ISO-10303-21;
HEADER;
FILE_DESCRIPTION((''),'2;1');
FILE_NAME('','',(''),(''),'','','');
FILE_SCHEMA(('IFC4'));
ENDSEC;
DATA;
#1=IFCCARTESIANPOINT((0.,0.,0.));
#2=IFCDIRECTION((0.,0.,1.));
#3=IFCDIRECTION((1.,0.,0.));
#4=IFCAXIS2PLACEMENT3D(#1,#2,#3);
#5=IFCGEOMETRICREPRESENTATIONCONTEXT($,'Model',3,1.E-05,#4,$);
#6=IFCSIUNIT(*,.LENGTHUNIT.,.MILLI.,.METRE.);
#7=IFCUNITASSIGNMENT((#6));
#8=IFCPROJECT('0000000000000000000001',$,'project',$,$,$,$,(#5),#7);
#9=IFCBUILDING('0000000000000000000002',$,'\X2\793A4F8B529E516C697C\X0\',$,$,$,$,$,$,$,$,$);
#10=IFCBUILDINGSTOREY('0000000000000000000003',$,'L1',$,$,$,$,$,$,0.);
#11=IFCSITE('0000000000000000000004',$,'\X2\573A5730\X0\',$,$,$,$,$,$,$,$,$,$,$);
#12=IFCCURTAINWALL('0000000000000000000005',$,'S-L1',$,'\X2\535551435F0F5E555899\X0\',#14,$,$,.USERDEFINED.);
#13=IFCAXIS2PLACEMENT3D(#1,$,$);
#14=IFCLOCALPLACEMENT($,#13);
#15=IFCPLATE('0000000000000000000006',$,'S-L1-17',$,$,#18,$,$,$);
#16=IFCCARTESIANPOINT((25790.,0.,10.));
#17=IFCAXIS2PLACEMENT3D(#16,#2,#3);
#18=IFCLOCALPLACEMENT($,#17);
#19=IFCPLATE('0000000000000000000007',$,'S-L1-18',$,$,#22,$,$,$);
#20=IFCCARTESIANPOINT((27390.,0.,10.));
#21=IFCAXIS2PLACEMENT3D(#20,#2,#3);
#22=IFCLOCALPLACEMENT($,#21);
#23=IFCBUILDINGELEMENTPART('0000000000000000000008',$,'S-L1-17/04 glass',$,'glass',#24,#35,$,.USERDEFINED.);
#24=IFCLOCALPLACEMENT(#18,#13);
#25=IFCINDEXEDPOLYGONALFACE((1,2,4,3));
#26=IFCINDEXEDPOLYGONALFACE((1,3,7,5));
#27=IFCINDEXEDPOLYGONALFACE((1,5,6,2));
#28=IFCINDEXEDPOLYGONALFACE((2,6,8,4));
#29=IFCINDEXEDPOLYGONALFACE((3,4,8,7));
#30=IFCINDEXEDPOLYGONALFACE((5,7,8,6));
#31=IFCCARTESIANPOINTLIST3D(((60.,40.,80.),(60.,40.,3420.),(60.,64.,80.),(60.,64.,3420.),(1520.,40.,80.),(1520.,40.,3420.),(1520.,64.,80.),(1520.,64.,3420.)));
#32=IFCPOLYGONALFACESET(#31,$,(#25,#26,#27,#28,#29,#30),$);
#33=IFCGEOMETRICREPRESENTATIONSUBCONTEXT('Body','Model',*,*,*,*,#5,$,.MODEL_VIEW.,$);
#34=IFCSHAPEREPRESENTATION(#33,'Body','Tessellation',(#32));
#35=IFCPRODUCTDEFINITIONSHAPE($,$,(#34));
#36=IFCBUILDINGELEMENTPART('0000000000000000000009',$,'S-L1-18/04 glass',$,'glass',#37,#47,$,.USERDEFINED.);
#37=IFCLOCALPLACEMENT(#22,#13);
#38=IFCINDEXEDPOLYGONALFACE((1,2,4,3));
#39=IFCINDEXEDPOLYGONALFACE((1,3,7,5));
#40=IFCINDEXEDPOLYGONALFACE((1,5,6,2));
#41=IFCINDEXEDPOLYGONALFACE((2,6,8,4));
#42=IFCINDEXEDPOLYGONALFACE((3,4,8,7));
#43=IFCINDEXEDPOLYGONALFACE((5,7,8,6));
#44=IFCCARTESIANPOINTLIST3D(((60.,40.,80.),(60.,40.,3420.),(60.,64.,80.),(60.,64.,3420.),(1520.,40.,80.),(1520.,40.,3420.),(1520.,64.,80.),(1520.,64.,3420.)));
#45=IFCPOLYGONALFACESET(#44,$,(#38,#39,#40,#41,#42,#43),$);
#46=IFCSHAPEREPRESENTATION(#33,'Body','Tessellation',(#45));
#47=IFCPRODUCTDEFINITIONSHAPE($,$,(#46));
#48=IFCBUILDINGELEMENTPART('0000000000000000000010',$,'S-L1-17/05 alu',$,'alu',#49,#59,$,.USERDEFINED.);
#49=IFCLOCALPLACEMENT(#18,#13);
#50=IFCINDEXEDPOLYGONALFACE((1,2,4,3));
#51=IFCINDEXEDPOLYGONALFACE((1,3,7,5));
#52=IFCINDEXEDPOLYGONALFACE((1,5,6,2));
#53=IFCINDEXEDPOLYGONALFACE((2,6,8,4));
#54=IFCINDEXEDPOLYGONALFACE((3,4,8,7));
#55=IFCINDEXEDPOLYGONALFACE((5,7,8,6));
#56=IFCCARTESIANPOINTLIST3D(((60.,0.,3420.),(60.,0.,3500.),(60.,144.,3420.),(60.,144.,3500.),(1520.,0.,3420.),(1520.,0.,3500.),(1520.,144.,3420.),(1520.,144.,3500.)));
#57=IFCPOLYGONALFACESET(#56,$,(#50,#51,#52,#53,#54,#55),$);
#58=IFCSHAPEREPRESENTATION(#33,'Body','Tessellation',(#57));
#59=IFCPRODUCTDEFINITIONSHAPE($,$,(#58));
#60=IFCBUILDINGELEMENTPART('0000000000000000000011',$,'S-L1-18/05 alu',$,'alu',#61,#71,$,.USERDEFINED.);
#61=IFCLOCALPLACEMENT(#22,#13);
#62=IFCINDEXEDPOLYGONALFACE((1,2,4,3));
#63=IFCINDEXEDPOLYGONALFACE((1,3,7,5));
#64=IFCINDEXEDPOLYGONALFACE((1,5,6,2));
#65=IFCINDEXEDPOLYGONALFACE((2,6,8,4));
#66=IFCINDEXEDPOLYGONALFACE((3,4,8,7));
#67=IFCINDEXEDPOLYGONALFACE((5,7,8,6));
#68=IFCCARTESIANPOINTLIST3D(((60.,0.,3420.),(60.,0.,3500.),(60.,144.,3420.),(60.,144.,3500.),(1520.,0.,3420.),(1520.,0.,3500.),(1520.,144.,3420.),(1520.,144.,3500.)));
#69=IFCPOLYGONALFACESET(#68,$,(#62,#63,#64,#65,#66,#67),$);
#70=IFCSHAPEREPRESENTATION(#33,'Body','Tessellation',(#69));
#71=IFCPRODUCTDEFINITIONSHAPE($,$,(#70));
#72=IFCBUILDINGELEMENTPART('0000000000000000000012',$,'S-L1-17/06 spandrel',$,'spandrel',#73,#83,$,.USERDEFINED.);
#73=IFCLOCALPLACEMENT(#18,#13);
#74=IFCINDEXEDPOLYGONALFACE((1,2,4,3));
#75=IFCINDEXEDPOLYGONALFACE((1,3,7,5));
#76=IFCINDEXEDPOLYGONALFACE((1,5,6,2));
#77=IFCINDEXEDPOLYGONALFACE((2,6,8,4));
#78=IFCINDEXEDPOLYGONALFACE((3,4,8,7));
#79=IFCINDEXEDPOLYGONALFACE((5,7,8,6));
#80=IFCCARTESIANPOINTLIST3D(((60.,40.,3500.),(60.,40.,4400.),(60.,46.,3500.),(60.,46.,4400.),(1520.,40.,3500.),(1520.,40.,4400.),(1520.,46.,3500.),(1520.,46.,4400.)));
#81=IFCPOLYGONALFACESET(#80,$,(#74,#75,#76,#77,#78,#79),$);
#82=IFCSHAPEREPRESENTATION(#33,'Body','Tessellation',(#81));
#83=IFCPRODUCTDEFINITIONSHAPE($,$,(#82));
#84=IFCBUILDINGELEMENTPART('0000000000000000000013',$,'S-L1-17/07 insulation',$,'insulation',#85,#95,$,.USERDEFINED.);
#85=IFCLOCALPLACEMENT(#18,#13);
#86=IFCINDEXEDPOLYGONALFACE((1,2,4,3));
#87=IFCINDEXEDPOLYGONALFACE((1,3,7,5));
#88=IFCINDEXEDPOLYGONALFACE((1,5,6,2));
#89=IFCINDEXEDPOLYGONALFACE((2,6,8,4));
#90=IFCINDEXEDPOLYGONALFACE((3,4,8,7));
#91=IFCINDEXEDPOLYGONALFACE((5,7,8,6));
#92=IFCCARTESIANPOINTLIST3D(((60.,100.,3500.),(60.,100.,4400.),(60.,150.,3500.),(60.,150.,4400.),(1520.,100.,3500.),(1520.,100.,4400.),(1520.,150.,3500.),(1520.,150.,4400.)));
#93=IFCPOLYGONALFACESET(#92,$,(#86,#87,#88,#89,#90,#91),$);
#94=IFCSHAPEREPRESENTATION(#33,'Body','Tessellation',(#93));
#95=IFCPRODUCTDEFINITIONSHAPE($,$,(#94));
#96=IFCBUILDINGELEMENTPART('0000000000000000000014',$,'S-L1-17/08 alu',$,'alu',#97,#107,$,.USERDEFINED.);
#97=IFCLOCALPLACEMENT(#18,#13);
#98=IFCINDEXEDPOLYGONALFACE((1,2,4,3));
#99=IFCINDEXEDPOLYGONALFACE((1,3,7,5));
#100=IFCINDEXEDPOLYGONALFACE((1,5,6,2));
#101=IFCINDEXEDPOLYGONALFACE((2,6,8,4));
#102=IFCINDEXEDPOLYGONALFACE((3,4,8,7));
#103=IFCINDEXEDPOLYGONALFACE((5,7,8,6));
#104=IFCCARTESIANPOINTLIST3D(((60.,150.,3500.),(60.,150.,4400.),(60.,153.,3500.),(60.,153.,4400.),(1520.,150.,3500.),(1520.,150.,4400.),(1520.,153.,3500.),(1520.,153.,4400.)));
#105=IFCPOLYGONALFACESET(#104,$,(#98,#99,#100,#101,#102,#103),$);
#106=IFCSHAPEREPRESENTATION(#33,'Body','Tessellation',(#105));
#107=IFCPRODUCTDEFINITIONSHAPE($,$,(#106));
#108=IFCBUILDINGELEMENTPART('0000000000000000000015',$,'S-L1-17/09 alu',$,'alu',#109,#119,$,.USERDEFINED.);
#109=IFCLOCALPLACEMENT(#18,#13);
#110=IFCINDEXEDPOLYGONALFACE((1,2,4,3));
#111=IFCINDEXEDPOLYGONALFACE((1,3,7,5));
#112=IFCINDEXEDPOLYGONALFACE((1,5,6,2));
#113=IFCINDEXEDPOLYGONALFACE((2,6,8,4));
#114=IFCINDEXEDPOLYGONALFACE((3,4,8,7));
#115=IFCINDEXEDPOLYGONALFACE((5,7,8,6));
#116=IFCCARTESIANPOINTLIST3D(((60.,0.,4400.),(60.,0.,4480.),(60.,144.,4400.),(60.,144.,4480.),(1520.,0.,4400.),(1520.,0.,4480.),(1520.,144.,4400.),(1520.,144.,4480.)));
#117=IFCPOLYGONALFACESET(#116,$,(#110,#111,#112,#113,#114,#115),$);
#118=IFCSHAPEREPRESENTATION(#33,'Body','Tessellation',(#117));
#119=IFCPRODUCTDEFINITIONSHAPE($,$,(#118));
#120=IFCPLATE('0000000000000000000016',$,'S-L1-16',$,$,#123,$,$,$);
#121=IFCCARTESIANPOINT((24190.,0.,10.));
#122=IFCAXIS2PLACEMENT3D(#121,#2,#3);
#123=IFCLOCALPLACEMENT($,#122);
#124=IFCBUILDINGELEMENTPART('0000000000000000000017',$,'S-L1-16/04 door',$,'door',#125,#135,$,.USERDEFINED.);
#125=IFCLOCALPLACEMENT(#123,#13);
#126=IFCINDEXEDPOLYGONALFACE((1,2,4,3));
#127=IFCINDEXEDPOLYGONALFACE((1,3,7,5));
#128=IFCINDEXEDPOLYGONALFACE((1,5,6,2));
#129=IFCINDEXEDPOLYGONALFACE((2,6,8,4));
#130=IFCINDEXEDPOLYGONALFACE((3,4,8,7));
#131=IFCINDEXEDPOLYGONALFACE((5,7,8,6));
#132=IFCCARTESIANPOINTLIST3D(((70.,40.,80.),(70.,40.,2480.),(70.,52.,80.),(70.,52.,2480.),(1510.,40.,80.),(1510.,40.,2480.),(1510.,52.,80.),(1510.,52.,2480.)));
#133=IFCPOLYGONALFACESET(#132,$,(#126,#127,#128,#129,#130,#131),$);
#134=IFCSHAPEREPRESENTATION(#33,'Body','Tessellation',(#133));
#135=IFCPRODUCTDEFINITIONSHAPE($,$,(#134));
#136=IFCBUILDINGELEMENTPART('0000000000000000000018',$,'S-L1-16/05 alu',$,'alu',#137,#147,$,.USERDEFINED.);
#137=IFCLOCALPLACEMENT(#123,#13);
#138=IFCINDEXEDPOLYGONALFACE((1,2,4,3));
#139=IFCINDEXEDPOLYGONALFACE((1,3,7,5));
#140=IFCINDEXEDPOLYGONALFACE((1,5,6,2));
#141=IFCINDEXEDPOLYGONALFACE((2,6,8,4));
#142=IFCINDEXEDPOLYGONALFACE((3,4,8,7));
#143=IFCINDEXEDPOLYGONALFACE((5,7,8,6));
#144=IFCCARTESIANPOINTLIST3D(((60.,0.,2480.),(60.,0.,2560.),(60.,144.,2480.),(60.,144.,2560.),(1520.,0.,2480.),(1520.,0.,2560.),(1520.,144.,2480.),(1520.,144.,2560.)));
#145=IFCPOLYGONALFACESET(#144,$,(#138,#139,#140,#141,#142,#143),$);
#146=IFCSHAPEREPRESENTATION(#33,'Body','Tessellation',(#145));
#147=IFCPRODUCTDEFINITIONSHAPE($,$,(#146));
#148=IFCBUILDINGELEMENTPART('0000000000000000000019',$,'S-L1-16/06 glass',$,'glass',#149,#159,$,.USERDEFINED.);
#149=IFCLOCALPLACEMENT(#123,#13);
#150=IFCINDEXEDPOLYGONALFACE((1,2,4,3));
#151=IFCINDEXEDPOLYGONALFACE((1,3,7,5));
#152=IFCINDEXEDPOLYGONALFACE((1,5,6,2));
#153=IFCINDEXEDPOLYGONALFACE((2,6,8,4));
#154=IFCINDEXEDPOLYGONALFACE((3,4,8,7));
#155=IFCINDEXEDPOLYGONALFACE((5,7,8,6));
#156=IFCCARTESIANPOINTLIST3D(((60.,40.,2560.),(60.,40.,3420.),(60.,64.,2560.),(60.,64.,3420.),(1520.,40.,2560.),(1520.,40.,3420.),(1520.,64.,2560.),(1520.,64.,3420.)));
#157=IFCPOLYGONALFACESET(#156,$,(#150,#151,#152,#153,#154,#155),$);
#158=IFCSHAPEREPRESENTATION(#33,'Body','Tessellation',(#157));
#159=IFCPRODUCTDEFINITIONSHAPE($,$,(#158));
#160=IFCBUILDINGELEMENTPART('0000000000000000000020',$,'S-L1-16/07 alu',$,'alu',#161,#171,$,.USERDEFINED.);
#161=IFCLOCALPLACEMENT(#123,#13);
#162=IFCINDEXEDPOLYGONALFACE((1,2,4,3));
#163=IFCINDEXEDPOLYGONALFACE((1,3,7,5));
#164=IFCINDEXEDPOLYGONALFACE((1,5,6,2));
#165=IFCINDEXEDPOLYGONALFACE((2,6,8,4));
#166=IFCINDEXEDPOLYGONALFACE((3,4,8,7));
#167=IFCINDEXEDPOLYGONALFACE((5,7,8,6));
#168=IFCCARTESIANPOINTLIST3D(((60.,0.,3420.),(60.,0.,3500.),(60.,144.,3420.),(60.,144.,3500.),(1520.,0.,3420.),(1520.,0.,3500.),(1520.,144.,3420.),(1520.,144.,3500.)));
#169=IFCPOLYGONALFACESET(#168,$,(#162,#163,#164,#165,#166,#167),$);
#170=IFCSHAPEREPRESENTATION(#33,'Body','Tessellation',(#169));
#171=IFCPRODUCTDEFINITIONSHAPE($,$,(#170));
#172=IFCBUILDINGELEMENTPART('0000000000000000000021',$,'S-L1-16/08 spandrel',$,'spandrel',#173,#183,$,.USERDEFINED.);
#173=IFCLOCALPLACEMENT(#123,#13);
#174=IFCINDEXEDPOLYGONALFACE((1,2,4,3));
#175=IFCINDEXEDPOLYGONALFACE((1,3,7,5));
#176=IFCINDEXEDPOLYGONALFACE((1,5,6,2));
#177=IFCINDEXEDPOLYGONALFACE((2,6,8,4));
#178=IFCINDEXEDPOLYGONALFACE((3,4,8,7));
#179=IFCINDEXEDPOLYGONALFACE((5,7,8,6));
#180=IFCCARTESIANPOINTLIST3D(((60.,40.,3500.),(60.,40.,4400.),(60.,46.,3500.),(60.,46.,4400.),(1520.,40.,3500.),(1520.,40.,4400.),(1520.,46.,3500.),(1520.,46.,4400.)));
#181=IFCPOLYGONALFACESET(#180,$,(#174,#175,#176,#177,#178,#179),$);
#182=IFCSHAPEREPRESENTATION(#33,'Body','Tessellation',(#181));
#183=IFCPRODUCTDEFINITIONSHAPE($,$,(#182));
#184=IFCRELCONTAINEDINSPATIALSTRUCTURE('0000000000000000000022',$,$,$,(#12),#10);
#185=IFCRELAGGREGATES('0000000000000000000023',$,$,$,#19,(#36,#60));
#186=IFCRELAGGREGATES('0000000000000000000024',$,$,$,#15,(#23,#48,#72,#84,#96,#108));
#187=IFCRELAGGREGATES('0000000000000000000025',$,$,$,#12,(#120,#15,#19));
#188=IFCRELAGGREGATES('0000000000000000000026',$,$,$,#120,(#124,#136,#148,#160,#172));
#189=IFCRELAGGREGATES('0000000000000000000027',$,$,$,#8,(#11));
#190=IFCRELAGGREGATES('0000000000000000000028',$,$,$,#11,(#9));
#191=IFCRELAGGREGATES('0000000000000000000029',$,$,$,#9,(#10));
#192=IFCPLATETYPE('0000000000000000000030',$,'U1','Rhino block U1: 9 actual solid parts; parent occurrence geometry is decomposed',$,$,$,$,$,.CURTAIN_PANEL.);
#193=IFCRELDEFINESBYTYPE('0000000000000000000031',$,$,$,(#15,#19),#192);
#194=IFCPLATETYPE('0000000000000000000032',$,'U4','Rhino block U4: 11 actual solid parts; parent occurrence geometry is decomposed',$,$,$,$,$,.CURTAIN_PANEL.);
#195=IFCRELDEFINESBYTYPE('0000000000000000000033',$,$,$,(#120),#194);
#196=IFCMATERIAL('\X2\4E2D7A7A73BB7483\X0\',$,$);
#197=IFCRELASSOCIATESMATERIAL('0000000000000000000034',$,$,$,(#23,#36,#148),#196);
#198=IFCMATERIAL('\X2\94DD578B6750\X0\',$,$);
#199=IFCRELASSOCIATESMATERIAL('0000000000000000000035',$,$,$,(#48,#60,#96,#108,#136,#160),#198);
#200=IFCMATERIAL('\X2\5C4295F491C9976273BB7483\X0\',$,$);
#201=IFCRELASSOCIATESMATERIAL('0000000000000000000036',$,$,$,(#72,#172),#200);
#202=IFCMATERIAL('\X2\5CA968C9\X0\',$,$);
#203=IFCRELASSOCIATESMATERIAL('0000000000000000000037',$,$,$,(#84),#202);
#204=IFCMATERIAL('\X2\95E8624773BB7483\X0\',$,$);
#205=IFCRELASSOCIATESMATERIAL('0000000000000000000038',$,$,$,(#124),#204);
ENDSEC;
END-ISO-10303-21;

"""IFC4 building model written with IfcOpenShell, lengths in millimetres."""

from ifc_helpers import new_model, si_unit, frame, frame_2d, origin, origin_with_axes, place, context, subcontext, project, spatial, rectangle, extrude, source, transform, mapped, material, type_object, element, aggregate, save


model = new_model("IFC4")

# Units and contexts
model_context = context("Model", 3, precision=1e-05, world=origin_with_axes())
body_context = subcontext(model_context, "Body", "Model", "MODEL_VIEW")
ifc_project = project(units=[si_unit("LENGTHUNIT", "METRE", prefix="MILLI")], contexts=[model_context])

# Site, building, storey
site = spatial("IfcSite", under=ifc_project, Name="场地")
building = spatial("IfcBuilding", under=site, Name="示例办公楼")
storey = spatial("IfcBuildingStorey", under=building, Name="L1", Elevation=0.0)

# Curtain wall, plates, building element parts
curtain_wall = element("IfcCurtainWall", 1, inside=storey, Name="S-L1", ObjectType="单元式幕墙", PredefinedType="USERDEFINED")
plate_type_1 = type_object("IfcPlateType", Name="U1", Description="Rhino block U1: 9 actual solid parts; parent occurrence geometry is decomposed", PredefinedType="CURTAIN_PANEL")
plate_1_placement = place(None, frame((25790.0, 0.0, 10.0), z_axis=(0.0, 0.0, 1.0), x_axis=(1.0, 0.0, 0.0)))
plate_1 = element("IfcPlate", 2, at=plate_1_placement, type_object=plate_type_1, Name="S-L1-17")
ifc_material_1 = material(Name="铝型材")
plate_2_placement = place(None, frame((27390.0, 0.0, 10.0), z_axis=(0.0, 0.0, 1.0), x_axis=(1.0, 0.0, 0.0)))
plate_2 = element("IfcPlate", 3, at=plate_2_placement, type_object=plate_type_1, Name="S-L1-18")
ifc_material_2 = material(Name="中空玻璃")
shared_shape_1 = source(origin(), body_context, "Body", "SweptSolid", [
    extrude(rectangle(XDim=1460.0, YDim=24.0, at=frame_2d((790.0, 52.0))), frame((0.0, 0.0, 80.0)), (0.0, 0.0, 1.0), 3340.0),
])
building_element_part_1_placement = place(plate_1_placement, origin())
building_element_part_1 = element("IfcBuildingElementPart", 4, at=building_element_part_1_placement, material=ifc_material_2, Name="S-L1-17/04 glass", ObjectType="glass", PredefinedType="USERDEFINED", context=body_context, shape_type="MappedRepresentation", body=[
    mapped(shared_shape_1, transform((0.0, 0.0, 0.0))),
])
building_element_part_2_placement = place(plate_2_placement, origin())
building_element_part_2 = element("IfcBuildingElementPart", 5, at=building_element_part_2_placement, material=ifc_material_2, Name="S-L1-18/04 glass", ObjectType="glass", PredefinedType="USERDEFINED", context=body_context, shape_type="MappedRepresentation", body=[
    mapped(shared_shape_1, transform((0.0, 0.0, 0.0))),
])
shared_shape_2 = source(origin(), body_context, "Body", "SweptSolid", [
    extrude(rectangle(XDim=1460.0, YDim=144.0, at=frame_2d((790.0, 72.0))), frame((0.0, 0.0, 3420.0)), (0.0, 0.0, 1.0), 80.0),
])
building_element_part_3_placement = place(plate_1_placement, origin())
building_element_part_3 = element("IfcBuildingElementPart", 6, at=building_element_part_3_placement, material=ifc_material_1, Name="S-L1-17/05 alu", ObjectType="alu", PredefinedType="USERDEFINED", context=body_context, shape_type="MappedRepresentation", body=[
    mapped(shared_shape_2, transform((0.0, 0.0, 0.0))),
])
building_element_part_4_placement = place(plate_2_placement, origin())
building_element_part_4 = element("IfcBuildingElementPart", 7, at=building_element_part_4_placement, material=ifc_material_1, Name="S-L1-18/05 alu", ObjectType="alu", PredefinedType="USERDEFINED", context=body_context, shape_type="MappedRepresentation", body=[
    mapped(shared_shape_2, transform((0.0, 0.0, 0.0))),
])
aggregate(plate_2, [building_element_part_2, building_element_part_4])
ifc_material_3 = material(Name="层间釉面玻璃")
shared_shape_3 = source(origin(), body_context, "Body", "SweptSolid", [
    extrude(rectangle(XDim=1460.0, YDim=6.0, at=frame_2d((790.0, 43.0))), frame((0.0, 0.0, 3500.0)), (0.0, 0.0, 1.0), 900.0),
])
building_element_part_5_placement = place(plate_1_placement, origin())
building_element_part_5 = element("IfcBuildingElementPart", 8, at=building_element_part_5_placement, material=ifc_material_3, Name="S-L1-17/06 spandrel", ObjectType="spandrel", PredefinedType="USERDEFINED", context=body_context, shape_type="MappedRepresentation", body=[
    mapped(shared_shape_3, transform((0.0, 0.0, 0.0))),
])
ifc_material_4 = material(Name="岩棉")
shared_shape_4 = source(origin(), body_context, "Body", "SweptSolid", [
    extrude(rectangle(XDim=1460.0, YDim=50.0, at=frame_2d((790.0, 125.0))), frame((0.0, 0.0, 3500.0)), (0.0, 0.0, 1.0), 900.0),
])
building_element_part_6_placement = place(plate_1_placement, origin())
building_element_part_6 = element("IfcBuildingElementPart", 9, at=building_element_part_6_placement, material=ifc_material_4, Name="S-L1-17/07 insulation", ObjectType="insulation", PredefinedType="USERDEFINED", context=body_context, shape_type="MappedRepresentation", body=[
    mapped(shared_shape_4, transform((0.0, 0.0, 0.0))),
])
shared_shape_5 = source(origin(), body_context, "Body", "SweptSolid", [
    extrude(rectangle(XDim=1460.0, YDim=3.0, at=frame_2d((790.0, 151.5))), frame((0.0, 0.0, 3500.0)), (0.0, 0.0, 1.0), 900.0),
])
building_element_part_7_placement = place(plate_1_placement, origin())
building_element_part_7 = element("IfcBuildingElementPart", 10, at=building_element_part_7_placement, material=ifc_material_1, Name="S-L1-17/08 alu", ObjectType="alu", PredefinedType="USERDEFINED", context=body_context, shape_type="MappedRepresentation", body=[
    mapped(shared_shape_5, transform((0.0, 0.0, 0.0))),
])
shared_shape_6 = source(origin(), body_context, "Body", "SweptSolid", [
    extrude(rectangle(XDim=1460.0, YDim=144.0, at=frame_2d((790.0, 72.0))), frame((0.0, 0.0, 4400.0)), (0.0, 0.0, 1.0), 80.0),
])
building_element_part_8_placement = place(plate_1_placement, origin())
building_element_part_8 = element("IfcBuildingElementPart", 11, at=building_element_part_8_placement, material=ifc_material_1, Name="S-L1-17/09 alu", ObjectType="alu", PredefinedType="USERDEFINED", context=body_context, shape_type="MappedRepresentation", body=[
    mapped(shared_shape_6, transform((0.0, 0.0, 0.0))),
])
aggregate(plate_1, [building_element_part_1, building_element_part_3, building_element_part_5, building_element_part_6, building_element_part_7, building_element_part_8])
plate_type_2 = type_object("IfcPlateType", Name="U4", Description="Rhino block U4: 11 actual solid parts; parent occurrence geometry is decomposed", PredefinedType="CURTAIN_PANEL")
plate_3_placement = place(None, frame((24190.0, 0.0, 10.0), z_axis=(0.0, 0.0, 1.0), x_axis=(1.0, 0.0, 0.0)))
plate_3 = element("IfcPlate", 12, at=plate_3_placement, type_object=plate_type_2, Name="S-L1-16")
aggregate(curtain_wall, [plate_3, plate_1, plate_2])
ifc_material_5 = material(Name="门扇玻璃")
shared_shape_7 = source(origin(), body_context, "Body", "SweptSolid", [
    extrude(rectangle(XDim=1440.0, YDim=12.0, at=frame_2d((790.0, 46.0))), frame((0.0, 0.0, 80.0)), (0.0, 0.0, 1.0), 2400.0),
])
building_element_part_9_placement = place(plate_3_placement, origin())
building_element_part_9 = element("IfcBuildingElementPart", 13, at=building_element_part_9_placement, material=ifc_material_5, Name="S-L1-16/04 door", ObjectType="door", PredefinedType="USERDEFINED", context=body_context, shape_type="MappedRepresentation", body=[
    mapped(shared_shape_7, transform((0.0, 0.0, 0.0))),
])
shared_shape_8 = source(origin(), body_context, "Body", "SweptSolid", [
    extrude(rectangle(XDim=1460.0, YDim=144.0, at=frame_2d((790.0, 72.0))), frame((0.0, 0.0, 2480.0)), (0.0, 0.0, 1.0), 80.0),
])
building_element_part_10_placement = place(plate_3_placement, origin())
building_element_part_10 = element("IfcBuildingElementPart", 14, at=building_element_part_10_placement, material=ifc_material_1, Name="S-L1-16/05 alu", ObjectType="alu", PredefinedType="USERDEFINED", context=body_context, shape_type="MappedRepresentation", body=[
    mapped(shared_shape_8, transform((0.0, 0.0, 0.0))),
])
shared_shape_9 = source(origin(), body_context, "Body", "SweptSolid", [
    extrude(rectangle(XDim=1460.0, YDim=24.0, at=frame_2d((790.0, 52.0))), frame((0.0, 0.0, 2560.0)), (0.0, 0.0, 1.0), 860.0),
])
building_element_part_11_placement = place(plate_3_placement, origin())
building_element_part_11 = element("IfcBuildingElementPart", 15, at=building_element_part_11_placement, material=ifc_material_2, Name="S-L1-16/06 glass", ObjectType="glass", PredefinedType="USERDEFINED", context=body_context, shape_type="MappedRepresentation", body=[
    mapped(shared_shape_9, transform((0.0, 0.0, 0.0))),
])
shared_shape_10 = source(origin(), body_context, "Body", "SweptSolid", [
    extrude(rectangle(XDim=1460.0, YDim=144.0, at=frame_2d((790.0, 72.0))), frame((0.0, 0.0, 3420.0)), (0.0, 0.0, 1.0), 80.0),
])
building_element_part_12_placement = place(plate_3_placement, origin())
building_element_part_12 = element("IfcBuildingElementPart", 16, at=building_element_part_12_placement, material=ifc_material_1, Name="S-L1-16/07 alu", ObjectType="alu", PredefinedType="USERDEFINED", context=body_context, shape_type="MappedRepresentation", body=[
    mapped(shared_shape_10, transform((0.0, 0.0, 0.0))),
])
shared_shape_11 = source(origin(), body_context, "Body", "SweptSolid", [
    extrude(rectangle(XDim=1460.0, YDim=6.0, at=frame_2d((790.0, 43.0))), frame((0.0, 0.0, 3500.0)), (0.0, 0.0, 1.0), 900.0),
])
building_element_part_13_placement = place(plate_3_placement, origin())
building_element_part_13 = element("IfcBuildingElementPart", 17, at=building_element_part_13_placement, material=ifc_material_3, Name="S-L1-16/08 spandrel", ObjectType="spandrel", PredefinedType="USERDEFINED", context=body_context, shape_type="MappedRepresentation", body=[
    mapped(shared_shape_11, transform((0.0, 0.0, 0.0))),
])
aggregate(plate_3, [building_element_part_9, building_element_part_10, building_element_part_11, building_element_part_12, building_element_part_13])

save(model, "model.ifc")
